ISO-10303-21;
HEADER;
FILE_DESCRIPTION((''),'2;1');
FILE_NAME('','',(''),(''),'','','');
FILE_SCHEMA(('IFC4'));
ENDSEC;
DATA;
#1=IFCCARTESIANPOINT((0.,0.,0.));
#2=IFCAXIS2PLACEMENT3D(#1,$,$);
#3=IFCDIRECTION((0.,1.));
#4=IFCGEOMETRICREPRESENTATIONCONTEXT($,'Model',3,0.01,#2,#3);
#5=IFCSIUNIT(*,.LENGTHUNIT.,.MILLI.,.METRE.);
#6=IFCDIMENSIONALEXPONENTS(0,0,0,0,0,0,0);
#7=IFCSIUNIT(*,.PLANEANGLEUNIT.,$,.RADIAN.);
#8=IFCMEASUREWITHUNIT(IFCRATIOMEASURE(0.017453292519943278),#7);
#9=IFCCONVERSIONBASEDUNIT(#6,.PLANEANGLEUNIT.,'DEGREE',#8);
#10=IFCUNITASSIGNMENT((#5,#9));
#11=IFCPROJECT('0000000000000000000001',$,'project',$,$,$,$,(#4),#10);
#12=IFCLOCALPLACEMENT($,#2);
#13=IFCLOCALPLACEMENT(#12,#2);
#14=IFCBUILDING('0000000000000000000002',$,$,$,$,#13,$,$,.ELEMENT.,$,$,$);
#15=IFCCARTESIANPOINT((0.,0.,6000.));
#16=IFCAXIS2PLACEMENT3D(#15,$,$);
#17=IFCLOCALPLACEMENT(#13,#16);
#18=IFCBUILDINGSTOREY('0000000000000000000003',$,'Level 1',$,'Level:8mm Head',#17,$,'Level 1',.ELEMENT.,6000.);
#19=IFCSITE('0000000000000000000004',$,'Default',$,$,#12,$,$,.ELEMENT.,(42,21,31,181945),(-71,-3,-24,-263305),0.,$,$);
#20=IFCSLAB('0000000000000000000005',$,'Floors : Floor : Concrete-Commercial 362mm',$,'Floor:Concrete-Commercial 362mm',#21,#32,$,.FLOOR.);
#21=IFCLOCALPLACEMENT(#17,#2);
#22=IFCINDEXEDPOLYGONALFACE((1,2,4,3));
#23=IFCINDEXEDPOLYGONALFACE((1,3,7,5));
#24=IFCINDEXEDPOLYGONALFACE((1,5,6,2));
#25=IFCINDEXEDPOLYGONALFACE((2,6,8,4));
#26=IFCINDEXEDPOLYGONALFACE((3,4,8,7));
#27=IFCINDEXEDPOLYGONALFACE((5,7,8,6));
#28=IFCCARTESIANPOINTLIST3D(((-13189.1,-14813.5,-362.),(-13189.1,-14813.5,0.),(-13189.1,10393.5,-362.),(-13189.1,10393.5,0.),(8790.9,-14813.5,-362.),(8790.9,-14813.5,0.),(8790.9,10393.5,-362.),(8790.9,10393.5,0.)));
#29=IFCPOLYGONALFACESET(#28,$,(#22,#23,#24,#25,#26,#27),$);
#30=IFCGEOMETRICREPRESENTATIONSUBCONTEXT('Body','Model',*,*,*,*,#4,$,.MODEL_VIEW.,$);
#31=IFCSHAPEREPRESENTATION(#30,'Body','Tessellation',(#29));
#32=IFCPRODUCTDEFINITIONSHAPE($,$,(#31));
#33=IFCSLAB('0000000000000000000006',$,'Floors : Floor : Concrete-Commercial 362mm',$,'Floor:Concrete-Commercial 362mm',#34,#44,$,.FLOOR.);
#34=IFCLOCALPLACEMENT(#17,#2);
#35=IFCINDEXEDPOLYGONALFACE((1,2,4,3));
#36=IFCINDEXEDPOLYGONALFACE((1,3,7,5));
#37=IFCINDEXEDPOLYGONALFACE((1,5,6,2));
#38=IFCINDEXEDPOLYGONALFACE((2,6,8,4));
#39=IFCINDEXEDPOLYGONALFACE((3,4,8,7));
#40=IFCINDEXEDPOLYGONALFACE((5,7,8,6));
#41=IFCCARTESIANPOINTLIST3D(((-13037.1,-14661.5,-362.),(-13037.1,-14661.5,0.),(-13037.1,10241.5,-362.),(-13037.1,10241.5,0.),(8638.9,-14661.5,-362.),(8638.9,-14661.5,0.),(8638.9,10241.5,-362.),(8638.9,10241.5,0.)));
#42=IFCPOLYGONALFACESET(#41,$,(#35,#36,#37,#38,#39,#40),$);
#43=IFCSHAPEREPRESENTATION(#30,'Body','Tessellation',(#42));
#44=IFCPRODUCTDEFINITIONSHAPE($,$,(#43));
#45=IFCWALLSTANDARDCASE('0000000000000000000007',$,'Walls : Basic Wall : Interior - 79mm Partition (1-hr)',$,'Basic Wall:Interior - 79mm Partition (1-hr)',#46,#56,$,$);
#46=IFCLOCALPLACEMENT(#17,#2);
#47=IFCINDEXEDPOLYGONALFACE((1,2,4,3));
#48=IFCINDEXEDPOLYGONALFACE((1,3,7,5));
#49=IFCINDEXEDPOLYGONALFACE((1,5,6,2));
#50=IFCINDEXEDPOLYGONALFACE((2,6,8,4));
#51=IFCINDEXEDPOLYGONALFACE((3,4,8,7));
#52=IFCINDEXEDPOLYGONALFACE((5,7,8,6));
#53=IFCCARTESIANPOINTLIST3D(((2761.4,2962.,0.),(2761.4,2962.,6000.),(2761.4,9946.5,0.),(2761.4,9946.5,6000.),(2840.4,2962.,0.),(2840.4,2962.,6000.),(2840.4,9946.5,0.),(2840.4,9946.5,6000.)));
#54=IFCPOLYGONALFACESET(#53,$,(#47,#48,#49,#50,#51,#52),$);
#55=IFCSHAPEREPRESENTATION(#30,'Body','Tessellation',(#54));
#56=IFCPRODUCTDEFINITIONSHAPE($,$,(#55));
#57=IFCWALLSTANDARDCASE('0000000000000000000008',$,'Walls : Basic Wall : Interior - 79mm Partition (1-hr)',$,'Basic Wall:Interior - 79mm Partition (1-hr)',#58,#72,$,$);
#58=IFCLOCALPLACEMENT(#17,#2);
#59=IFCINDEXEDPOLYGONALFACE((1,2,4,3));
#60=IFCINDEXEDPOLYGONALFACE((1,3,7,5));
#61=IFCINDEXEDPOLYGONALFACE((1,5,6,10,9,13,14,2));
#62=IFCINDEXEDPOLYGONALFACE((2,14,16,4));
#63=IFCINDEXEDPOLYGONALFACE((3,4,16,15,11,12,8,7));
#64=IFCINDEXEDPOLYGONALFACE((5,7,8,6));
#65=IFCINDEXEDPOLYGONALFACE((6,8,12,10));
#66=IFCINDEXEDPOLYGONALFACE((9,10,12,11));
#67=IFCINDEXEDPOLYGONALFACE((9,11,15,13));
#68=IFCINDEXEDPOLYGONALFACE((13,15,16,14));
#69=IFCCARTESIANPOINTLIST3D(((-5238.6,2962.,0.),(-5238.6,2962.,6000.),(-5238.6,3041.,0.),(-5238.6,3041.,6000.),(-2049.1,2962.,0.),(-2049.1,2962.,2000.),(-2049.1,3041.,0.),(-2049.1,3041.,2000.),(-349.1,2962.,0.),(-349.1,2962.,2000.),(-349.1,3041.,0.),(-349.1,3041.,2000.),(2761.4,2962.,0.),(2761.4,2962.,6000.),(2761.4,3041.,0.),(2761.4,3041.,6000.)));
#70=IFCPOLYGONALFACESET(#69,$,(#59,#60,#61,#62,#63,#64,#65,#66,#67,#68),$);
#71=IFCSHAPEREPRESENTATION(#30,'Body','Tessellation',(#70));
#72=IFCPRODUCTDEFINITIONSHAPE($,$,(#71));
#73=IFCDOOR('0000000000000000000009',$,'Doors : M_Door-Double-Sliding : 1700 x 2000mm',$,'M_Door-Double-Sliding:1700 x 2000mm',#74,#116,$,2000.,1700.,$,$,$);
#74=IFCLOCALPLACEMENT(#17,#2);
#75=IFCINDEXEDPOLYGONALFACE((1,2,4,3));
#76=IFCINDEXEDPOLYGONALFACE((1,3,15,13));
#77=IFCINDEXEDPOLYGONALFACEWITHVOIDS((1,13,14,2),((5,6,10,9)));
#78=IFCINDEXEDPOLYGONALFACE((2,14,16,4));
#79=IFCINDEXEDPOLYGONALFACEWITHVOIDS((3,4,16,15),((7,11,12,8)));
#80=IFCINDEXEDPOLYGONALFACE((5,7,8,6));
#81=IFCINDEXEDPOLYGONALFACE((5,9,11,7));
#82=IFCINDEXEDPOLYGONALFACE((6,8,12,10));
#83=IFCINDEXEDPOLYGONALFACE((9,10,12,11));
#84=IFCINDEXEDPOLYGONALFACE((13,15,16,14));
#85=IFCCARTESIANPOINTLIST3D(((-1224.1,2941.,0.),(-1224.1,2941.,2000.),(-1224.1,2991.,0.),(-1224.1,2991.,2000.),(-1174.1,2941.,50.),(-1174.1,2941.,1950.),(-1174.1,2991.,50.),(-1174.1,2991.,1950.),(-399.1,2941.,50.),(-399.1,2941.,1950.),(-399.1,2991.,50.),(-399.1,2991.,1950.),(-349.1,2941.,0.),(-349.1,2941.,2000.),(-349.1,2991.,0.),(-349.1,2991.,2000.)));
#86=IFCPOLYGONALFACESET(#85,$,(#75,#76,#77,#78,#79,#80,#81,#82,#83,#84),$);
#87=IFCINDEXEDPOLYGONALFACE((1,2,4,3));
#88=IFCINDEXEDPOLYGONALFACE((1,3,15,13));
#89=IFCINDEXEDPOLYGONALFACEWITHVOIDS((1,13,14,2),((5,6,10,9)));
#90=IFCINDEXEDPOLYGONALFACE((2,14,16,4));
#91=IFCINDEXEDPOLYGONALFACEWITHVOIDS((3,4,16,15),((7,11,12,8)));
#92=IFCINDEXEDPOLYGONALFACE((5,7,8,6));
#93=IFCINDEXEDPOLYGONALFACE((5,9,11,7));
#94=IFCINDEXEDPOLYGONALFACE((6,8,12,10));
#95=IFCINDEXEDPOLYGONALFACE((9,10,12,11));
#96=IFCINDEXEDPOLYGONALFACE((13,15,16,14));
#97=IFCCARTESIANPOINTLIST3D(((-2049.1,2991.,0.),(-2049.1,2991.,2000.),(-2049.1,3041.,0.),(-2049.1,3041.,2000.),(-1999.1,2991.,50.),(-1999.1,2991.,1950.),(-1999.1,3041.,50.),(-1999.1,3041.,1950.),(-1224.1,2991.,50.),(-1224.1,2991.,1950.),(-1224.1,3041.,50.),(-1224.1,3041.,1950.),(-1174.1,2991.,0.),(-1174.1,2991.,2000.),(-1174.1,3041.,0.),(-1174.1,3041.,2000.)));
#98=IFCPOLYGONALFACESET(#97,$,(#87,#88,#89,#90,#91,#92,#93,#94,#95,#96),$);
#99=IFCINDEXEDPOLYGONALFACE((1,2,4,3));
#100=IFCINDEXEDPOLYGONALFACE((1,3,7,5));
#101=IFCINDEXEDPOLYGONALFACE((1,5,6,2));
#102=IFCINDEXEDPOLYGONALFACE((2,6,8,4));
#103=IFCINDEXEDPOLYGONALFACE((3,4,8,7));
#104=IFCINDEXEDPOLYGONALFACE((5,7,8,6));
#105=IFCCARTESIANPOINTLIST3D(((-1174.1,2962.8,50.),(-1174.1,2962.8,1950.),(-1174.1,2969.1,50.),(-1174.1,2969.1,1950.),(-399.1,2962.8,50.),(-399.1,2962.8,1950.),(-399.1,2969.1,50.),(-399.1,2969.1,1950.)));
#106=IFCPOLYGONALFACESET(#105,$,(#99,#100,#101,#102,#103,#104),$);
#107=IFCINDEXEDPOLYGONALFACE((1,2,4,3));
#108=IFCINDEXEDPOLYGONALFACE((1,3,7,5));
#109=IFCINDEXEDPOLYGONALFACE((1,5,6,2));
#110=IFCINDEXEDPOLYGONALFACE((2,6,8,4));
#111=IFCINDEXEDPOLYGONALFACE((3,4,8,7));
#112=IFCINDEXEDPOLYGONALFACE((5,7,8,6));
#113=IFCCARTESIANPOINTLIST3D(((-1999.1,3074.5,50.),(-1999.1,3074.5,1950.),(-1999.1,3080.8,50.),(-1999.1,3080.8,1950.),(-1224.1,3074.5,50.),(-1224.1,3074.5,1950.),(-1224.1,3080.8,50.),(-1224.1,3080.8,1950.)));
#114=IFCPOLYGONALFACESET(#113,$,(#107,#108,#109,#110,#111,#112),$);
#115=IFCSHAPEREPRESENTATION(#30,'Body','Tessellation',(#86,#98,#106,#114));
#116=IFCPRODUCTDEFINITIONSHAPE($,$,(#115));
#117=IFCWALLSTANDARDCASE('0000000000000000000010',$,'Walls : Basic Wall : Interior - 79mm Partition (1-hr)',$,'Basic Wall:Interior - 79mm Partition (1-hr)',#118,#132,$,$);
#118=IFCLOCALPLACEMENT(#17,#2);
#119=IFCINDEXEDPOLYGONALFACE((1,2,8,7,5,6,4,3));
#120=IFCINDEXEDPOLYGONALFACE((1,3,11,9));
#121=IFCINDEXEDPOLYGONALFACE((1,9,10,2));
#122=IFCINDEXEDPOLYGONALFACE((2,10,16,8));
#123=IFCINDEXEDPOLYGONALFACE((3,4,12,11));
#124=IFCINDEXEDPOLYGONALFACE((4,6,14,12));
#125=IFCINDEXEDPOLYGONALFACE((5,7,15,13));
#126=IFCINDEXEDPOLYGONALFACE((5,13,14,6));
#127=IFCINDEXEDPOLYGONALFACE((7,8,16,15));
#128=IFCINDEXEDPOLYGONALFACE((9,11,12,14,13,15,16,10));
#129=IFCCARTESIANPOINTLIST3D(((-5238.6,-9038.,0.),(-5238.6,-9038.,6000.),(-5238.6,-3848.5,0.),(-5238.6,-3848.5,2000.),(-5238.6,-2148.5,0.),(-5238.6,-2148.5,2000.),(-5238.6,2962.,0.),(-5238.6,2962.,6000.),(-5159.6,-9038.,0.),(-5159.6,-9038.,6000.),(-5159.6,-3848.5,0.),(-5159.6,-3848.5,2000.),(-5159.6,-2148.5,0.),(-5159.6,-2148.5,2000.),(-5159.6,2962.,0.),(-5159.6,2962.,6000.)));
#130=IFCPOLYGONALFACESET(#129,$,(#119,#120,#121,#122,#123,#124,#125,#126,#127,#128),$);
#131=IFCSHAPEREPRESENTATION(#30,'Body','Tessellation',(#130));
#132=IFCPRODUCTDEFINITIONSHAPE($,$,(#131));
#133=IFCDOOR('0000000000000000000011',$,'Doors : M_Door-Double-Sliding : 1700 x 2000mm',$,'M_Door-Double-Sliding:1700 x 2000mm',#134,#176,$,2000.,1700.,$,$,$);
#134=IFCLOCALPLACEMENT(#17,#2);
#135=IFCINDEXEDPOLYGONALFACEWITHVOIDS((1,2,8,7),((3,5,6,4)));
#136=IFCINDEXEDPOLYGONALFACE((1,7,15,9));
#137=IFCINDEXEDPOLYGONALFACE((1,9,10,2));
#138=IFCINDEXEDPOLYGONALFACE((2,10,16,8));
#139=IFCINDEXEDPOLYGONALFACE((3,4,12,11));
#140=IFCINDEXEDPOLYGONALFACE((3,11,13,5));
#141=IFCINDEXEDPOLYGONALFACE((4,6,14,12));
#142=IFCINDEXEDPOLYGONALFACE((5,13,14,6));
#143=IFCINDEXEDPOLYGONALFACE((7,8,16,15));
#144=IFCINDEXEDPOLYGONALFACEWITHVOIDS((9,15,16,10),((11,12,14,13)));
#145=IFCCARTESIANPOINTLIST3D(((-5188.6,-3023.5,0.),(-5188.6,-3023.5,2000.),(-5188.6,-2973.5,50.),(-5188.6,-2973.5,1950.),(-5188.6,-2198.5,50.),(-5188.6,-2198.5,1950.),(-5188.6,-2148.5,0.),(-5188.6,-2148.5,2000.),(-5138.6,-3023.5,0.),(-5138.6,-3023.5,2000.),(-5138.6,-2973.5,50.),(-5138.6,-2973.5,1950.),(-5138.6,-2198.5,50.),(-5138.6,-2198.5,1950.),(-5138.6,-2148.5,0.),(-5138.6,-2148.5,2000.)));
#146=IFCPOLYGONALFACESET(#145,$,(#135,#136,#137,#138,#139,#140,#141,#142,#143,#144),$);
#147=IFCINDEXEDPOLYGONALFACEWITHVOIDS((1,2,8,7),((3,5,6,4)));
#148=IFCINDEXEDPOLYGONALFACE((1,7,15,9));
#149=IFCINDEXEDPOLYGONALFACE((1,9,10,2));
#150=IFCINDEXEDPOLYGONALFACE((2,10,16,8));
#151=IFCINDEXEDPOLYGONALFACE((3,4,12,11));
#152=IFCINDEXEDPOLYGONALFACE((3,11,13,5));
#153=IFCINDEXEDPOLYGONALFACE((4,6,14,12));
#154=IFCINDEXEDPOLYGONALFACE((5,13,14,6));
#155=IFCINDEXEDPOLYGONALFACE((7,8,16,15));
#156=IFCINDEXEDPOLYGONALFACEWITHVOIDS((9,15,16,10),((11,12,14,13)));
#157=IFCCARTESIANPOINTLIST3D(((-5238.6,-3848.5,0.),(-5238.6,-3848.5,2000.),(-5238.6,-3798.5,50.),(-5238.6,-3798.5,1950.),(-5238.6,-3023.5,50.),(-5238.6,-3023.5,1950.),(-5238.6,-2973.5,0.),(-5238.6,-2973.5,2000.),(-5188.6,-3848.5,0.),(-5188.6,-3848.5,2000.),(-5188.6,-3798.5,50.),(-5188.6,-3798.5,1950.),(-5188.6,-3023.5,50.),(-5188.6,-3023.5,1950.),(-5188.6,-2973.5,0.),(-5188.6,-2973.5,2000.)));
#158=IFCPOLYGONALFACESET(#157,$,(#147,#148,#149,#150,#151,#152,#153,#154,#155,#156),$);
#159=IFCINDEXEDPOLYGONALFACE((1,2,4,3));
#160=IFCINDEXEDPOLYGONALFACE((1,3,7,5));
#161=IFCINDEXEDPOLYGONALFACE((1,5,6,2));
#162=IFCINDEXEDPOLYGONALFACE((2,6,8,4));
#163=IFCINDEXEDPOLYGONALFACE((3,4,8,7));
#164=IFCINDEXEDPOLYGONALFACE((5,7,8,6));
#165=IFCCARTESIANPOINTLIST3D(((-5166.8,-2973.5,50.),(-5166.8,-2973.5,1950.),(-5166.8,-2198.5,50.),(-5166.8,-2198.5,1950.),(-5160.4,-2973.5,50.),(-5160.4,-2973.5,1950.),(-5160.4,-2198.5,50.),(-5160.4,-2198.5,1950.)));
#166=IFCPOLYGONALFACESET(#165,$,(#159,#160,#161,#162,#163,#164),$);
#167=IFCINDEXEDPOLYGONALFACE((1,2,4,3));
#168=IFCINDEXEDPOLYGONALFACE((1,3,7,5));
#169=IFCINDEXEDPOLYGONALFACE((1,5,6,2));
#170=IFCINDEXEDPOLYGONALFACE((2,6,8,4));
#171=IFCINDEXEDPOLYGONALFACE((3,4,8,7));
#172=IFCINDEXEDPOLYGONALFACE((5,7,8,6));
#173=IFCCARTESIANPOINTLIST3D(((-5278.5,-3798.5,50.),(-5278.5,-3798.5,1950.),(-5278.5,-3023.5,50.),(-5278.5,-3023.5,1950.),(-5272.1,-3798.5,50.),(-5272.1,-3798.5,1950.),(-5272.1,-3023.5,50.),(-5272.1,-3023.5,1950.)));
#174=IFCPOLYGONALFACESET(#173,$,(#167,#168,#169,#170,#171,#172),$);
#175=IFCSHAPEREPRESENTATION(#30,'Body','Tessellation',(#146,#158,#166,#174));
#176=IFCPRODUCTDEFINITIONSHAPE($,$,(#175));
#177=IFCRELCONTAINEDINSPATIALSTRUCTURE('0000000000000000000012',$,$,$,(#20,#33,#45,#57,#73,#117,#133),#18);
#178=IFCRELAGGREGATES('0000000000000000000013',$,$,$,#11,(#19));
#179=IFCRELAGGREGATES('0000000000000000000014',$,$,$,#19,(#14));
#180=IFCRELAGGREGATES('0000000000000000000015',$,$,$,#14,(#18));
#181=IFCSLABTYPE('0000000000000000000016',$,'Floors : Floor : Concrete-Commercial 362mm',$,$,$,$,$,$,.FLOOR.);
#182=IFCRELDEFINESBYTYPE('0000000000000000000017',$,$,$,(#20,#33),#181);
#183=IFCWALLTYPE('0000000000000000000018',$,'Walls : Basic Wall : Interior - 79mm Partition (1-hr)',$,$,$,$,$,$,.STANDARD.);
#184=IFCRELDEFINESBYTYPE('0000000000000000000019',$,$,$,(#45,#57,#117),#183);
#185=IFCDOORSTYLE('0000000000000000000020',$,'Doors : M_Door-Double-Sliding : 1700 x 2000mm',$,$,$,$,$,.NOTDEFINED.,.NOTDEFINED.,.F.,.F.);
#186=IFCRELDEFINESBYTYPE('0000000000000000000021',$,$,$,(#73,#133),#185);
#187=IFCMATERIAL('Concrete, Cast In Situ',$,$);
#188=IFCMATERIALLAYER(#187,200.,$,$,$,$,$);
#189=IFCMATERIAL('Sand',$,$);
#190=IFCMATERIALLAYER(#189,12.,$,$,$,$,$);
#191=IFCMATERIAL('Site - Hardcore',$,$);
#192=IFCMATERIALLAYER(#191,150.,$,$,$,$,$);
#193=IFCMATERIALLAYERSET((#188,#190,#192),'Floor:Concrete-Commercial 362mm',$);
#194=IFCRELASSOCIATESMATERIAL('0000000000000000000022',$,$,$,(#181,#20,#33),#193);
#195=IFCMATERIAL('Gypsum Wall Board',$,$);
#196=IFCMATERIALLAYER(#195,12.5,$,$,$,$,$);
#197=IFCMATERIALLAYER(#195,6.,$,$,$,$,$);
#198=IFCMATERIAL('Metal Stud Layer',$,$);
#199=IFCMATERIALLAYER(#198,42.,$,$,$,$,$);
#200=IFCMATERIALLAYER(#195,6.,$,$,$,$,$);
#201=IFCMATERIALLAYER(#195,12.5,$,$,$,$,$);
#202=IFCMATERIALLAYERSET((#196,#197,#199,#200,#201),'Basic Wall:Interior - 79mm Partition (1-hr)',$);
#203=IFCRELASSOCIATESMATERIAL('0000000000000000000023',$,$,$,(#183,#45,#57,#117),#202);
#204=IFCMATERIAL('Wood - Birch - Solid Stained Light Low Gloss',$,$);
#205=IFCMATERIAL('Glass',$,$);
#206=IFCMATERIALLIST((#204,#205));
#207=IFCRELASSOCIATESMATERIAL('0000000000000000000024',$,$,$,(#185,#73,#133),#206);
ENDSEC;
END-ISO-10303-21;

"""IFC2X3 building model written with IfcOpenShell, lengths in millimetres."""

from ifc_helpers import new_model, entity, si_unit, converted_unit, direction, frame, frame_2d, origin, origin_2d_with_axis, place, context, subcontext, project, spatial, polyline, rectangle, outline, extrude, source, transform, mapped, material, material_list, layer, layer_set, layer_usage, type_object, type_shapes, element, fill, save


model = new_model("IFC2X3")

# Units and contexts
model_context = context("Model", 3, precision=0.01, world=origin(), true_north=direction((0.0, 1.0)))
body_context = subcontext(model_context, "Body", "Model", "MODEL_VIEW")
ifc_project = project(units=[si_unit("LENGTHUNIT", "METRE", prefix="MILLI"), converted_unit("PLANEANGLEUNIT", "DEGREE", entity("IfcRatioMeasure", 0.017453292519943278), si_unit("PLANEANGLEUNIT", "RADIAN"), dimensions=[0, 0, 0, 0, 0, 0, 0])], contexts=[model_context])

# Site, building, storey
site_placement = place(None, origin())
site = spatial("IfcSite", under=ifc_project, at=site_placement, Name="Default", CompositionType="ELEMENT", RefLatitude=(42, 21, 31, 181945), RefLongitude=(-71, -3, -24, -263305), RefElevation=0.0)
building_placement = place(site_placement, origin())
building = spatial("IfcBuilding", under=site, at=building_placement, CompositionType="ELEMENT")
storey_placement = place(building_placement, frame((0.0, 0.0, 6000.0)))
storey = spatial("IfcBuildingStorey", under=building, at=storey_placement, Name="Level 1", ObjectType="Level:8mm Head", LongName="Level 1", CompositionType="ELEMENT", Elevation=6000.0)

# Slabs
ifc_material_1 = material(Name="Concrete, Cast In Situ")
ifc_layer_1 = layer(ifc_material_1, 200.0)
ifc_material_2 = material(Name="Sand")
ifc_layer_2 = layer(ifc_material_2, 12.0)
ifc_material_3 = material(Name="Site - Hardcore")
ifc_layer_3 = layer(ifc_material_3, 150.0)
ifc_layer_set_1 = layer_set([ifc_layer_1, ifc_layer_2, ifc_layer_3], Name="Floor:Concrete-Commercial 362mm")
ifc_layer_usage_1 = layer_usage(ifc_layer_set_1, "AXIS3", "POSITIVE", 0.0)
slab_type = type_object("IfcSlabType", Name="Floors : Floor : Concrete-Commercial 362mm", PredefinedType="FLOOR", material=ifc_layer_set_1)
slab_1_placement = place(storey_placement, origin())
element("IfcSlab", 1, at=slab_1_placement, inside=storey, type_object=slab_type, material=ifc_layer_usage_1, Name="Floors : Floor : Concrete-Commercial 362mm", ObjectType="Floor:Concrete-Commercial 362mm", PredefinedType="FLOOR", context=body_context, shape_type="SweptSolid", body=[
    extrude(rectangle(XDim=25207.0, YDim=21980.0, at=frame_2d((0.0, 0.0), x_axis=(1.0, 0.0))), frame((-2199.1, -2210.0, 0.0), z_axis=(0.0, 0.0, -1.0), x_axis=(0.0, 1.0, 0.0)), (0.0, 0.0, 1.0), 362.0),
])
slab_2_placement = place(storey_placement, origin())
element("IfcSlab", 2, at=slab_2_placement, inside=storey, type_object=slab_type, material=ifc_layer_usage_1, Name="Floors : Floor : Concrete-Commercial 362mm", ObjectType="Floor:Concrete-Commercial 362mm", PredefinedType="FLOOR", context=body_context, shape_type="SweptSolid", body=[
    extrude(rectangle(XDim=24903.0, YDim=21676.0, at=frame_2d((0.0, 0.0), x_axis=(1.0, 0.0))), frame((-2199.1, -2210.0, 0.0), z_axis=(0.0, 0.0, -1.0), x_axis=(0.0, 1.0, 0.0)), (0.0, 0.0, 1.0), 362.0),
])

# Wall
ifc_material_4 = material(Name="Gypsum Wall Board")
ifc_layer_4 = layer(ifc_material_4, 12.5)
ifc_layer_5 = layer(ifc_material_4, 6.0)
ifc_material_5 = material(Name="Metal Stud Layer")
ifc_layer_6 = layer(ifc_material_5, 42.0)
ifc_layer_7 = layer(ifc_material_4, 6.0)
ifc_layer_8 = layer(ifc_material_4, 12.5)
ifc_layer_set_2 = layer_set([ifc_layer_4, ifc_layer_5, ifc_layer_6, ifc_layer_7, ifc_layer_8], Name="Basic Wall:Interior - 79mm Partition (1-hr)")
ifc_layer_usage_2 = layer_usage(ifc_layer_set_2, "AXIS2", "NEGATIVE", 39.5)
wall_type = type_object("IfcWallType", Name="Walls : Basic Wall : Interior - 79mm Partition (1-hr)", PredefinedType="STANDARD", material=ifc_layer_set_2)
wall_1_placement = place(storey_placement, frame((2800.9, 9946.5, 0.0), z_axis=(0.0, 0.0, 1.0), x_axis=(0.0, -1.0, 0.0)))
element("IfcWallStandardCase", 3, at=wall_1_placement, inside=storey, type_object=wall_type, material=ifc_layer_usage_2, Name="Walls : Basic Wall : Interior - 79mm Partition (1-hr)", ObjectType="Basic Wall:Interior - 79mm Partition (1-hr)", context=body_context, shape_type="SweptSolid", body=[
    extrude(rectangle(XDim=6984.5, YDim=79.0, at=frame_2d((3492.3, 0.0), x_axis=(-1.0, 0.0))), origin(), (0.0, 0.0, 1.0), 6000.0),
])

# Walls, openings, doors
wall_2_placement = place(storey_placement, frame((2761.4, 3001.5, 0.0), z_axis=(0.0, 0.0, 1.0), x_axis=(-1.0, 0.0, 0.0)))
wall_2 = element("IfcWallStandardCase", 4, at=wall_2_placement, inside=storey, type_object=wall_type, material=ifc_layer_usage_2, Name="Walls : Basic Wall : Interior - 79mm Partition (1-hr)", ObjectType="Basic Wall:Interior - 79mm Partition (1-hr)", context=body_context, shape_type="SweptSolid", body=[
    extrude(rectangle(XDim=8000.0, YDim=79.0, at=frame_2d((4000.0, 0.0), x_axis=(-1.0, 0.0))), origin(), (0.0, 0.0, 1.0), 6000.0),
])
opening_1_placement = place(wall_2_placement, frame((4810.5, 39.5, 0.0)))
opening_1 = element("IfcOpeningElement", 5, at=opening_1_placement, cuts=wall_2, ObjectType="Opening", context=body_context, shape_type="SweptSolid", body=[
    extrude(rectangle(XDim=2000.0, YDim=1700.0, at=frame_2d((1000.0, 850.0), x_axis=(-1.0, 0.0))), frame((0.0, 0.0, 0.0), z_axis=(0.0, -1.0, 0.0), x_axis=(0.0, 0.0, 1.0)), (0.0, 0.0, 1.0), 79.0),
])
ifc_material_6 = material(Name="Wood - Birch - Solid Stained Light Low Gloss")
ifc_material_7 = material(Name="Glass")
ifc_material_list = material_list([ifc_material_6, ifc_material_7])
door_style = type_object("IfcDoorStyle", Name="Doors : M_Door-Double-Sliding : 1700 x 2000mm", ConstructionType="NOTDEFINED", OperationType="NOTDEFINED", ParameterTakesPrecedence=False, Sizeable=False, material=ifc_material_list)
shared_shape = source(origin(), body_context, "Body", "SweptSolid", [
    extrude(outline(polyline([(-437.5, -1000.0), (437.5, -1000.0), (437.5, 1000.0), (-437.5, 1000.0), (-437.5, -1000.0)]), holes=[polyline([(-387.5, -950.0), (-387.5, 950.0), (387.5, 950.0), (387.5, -950.0), (-387.5, -950.0)])]), frame((1262.5, -21.0, 1000.0), z_axis=(0.0, 1.0, 0.0), x_axis=(1.0, 0.0, 0.0)), (0.0, 0.0, 1.0), 50.0),
    extrude(outline(polyline([(-1000.0, -437.5), (1000.0, -437.5), (1000.0, 437.5), (-1000.0, 437.5), (-1000.0, -437.5)]), holes=[polyline([(-950.0, -387.5), (-950.0, 387.5), (950.0, 387.5), (950.0, -387.5), (-950.0, -387.5)])]), frame((437.5, 29.0, 1000.0), z_axis=(0.0, 1.0, 0.0), x_axis=(0.0, 0.0, -1.0)), (0.0, 0.0, 1.0), 50.0),
    extrude(rectangle(XDim=6.3, YDim=775.0, at=frame_2d((0.0, 0.0), x_axis=(1.0, 0.0))), frame((1262.5, 4.0, 50.0), z_axis=(0.0, 0.0, 1.0), x_axis=(0.0, -1.0, 0.0)), (0.0, 0.0, 1.0), 1900.0),
    extrude(rectangle(XDim=6.4, YDim=775.0, at=origin_2d_with_axis()), frame((437.5, 115.7, 50.0), z_axis=(0.0, 0.0, 1.0), x_axis=(0.0, 1.0, 0.0)), (0.0, 0.0, 1.0), 1900.0),
])
type_shapes(door_style, [shared_shape])
door_1_placement = place(opening_1_placement, frame((0.0, 0.0, 0.0), z_axis=(0.0, 0.0, 1.0), x_axis=(-1.0, 0.0, 0.0)))
door_1 = element("IfcDoor", 6, at=door_1_placement, inside=storey, type_object=door_style, material=ifc_material_list, Name="Doors : M_Door-Double-Sliding : 1700 x 2000mm", ObjectType="M_Door-Double-Sliding:1700 x 2000mm", OverallHeight=2000.0, OverallWidth=1700.0, context=body_context, shape_type="MappedRepresentation", body=[
    mapped(shared_shape, transform((0.0, 0.0, 0.0), scale=1.0)),
])
fill(opening_1, door_1)
wall_3_placement = place(storey_placement, frame((-5199.1, 2962.0, 0.0), z_axis=(0.0, 0.0, 1.0), x_axis=(0.0, -1.0, 0.0)))
wall_3 = element("IfcWallStandardCase", 7, at=wall_3_placement, inside=storey, type_object=wall_type, material=ifc_layer_usage_2, Name="Walls : Basic Wall : Interior - 79mm Partition (1-hr)", ObjectType="Basic Wall:Interior - 79mm Partition (1-hr)", context=body_context, shape_type="SweptSolid", body=[
    extrude(rectangle(XDim=12000.0, YDim=79.0, at=frame_2d((6000.0, 0.0), x_axis=(1.0, 0.0))), origin(), (0.0, 0.0, 1.0), 6000.0),
])
opening_2_placement = place(wall_3_placement, frame((6810.5, 39.5, 0.0)))
opening_2 = element("IfcOpeningElement", 8, at=opening_2_placement, cuts=wall_3, ObjectType="Opening", context=body_context, shape_type="SweptSolid", body=[
    extrude(rectangle(XDim=2000.0, YDim=1700.0, at=frame_2d((1000.0, 850.0), x_axis=(-1.0, 0.0))), frame((0.0, 0.0, 0.0), z_axis=(0.0, -1.0, 0.0), x_axis=(0.0, 0.0, 1.0)), (0.0, 0.0, 1.0), 79.0),
])
door_2_placement = place(opening_2_placement, frame((0.0, 0.0, 0.0), z_axis=(0.0, 0.0, 1.0), x_axis=(-1.0, 0.0, 0.0)))
door_2 = element("IfcDoor", 9, at=door_2_placement, inside=storey, type_object=door_style, material=ifc_material_list, Name="Doors : M_Door-Double-Sliding : 1700 x 2000mm", ObjectType="M_Door-Double-Sliding:1700 x 2000mm", OverallHeight=2000.0, OverallWidth=1700.0, context=body_context, shape_type="MappedRepresentation", body=[
    mapped(shared_shape, transform((0.0, 0.0, 0.0), scale=1.0)),
])
fill(opening_2, door_2)

save(model, "model.ifc")
